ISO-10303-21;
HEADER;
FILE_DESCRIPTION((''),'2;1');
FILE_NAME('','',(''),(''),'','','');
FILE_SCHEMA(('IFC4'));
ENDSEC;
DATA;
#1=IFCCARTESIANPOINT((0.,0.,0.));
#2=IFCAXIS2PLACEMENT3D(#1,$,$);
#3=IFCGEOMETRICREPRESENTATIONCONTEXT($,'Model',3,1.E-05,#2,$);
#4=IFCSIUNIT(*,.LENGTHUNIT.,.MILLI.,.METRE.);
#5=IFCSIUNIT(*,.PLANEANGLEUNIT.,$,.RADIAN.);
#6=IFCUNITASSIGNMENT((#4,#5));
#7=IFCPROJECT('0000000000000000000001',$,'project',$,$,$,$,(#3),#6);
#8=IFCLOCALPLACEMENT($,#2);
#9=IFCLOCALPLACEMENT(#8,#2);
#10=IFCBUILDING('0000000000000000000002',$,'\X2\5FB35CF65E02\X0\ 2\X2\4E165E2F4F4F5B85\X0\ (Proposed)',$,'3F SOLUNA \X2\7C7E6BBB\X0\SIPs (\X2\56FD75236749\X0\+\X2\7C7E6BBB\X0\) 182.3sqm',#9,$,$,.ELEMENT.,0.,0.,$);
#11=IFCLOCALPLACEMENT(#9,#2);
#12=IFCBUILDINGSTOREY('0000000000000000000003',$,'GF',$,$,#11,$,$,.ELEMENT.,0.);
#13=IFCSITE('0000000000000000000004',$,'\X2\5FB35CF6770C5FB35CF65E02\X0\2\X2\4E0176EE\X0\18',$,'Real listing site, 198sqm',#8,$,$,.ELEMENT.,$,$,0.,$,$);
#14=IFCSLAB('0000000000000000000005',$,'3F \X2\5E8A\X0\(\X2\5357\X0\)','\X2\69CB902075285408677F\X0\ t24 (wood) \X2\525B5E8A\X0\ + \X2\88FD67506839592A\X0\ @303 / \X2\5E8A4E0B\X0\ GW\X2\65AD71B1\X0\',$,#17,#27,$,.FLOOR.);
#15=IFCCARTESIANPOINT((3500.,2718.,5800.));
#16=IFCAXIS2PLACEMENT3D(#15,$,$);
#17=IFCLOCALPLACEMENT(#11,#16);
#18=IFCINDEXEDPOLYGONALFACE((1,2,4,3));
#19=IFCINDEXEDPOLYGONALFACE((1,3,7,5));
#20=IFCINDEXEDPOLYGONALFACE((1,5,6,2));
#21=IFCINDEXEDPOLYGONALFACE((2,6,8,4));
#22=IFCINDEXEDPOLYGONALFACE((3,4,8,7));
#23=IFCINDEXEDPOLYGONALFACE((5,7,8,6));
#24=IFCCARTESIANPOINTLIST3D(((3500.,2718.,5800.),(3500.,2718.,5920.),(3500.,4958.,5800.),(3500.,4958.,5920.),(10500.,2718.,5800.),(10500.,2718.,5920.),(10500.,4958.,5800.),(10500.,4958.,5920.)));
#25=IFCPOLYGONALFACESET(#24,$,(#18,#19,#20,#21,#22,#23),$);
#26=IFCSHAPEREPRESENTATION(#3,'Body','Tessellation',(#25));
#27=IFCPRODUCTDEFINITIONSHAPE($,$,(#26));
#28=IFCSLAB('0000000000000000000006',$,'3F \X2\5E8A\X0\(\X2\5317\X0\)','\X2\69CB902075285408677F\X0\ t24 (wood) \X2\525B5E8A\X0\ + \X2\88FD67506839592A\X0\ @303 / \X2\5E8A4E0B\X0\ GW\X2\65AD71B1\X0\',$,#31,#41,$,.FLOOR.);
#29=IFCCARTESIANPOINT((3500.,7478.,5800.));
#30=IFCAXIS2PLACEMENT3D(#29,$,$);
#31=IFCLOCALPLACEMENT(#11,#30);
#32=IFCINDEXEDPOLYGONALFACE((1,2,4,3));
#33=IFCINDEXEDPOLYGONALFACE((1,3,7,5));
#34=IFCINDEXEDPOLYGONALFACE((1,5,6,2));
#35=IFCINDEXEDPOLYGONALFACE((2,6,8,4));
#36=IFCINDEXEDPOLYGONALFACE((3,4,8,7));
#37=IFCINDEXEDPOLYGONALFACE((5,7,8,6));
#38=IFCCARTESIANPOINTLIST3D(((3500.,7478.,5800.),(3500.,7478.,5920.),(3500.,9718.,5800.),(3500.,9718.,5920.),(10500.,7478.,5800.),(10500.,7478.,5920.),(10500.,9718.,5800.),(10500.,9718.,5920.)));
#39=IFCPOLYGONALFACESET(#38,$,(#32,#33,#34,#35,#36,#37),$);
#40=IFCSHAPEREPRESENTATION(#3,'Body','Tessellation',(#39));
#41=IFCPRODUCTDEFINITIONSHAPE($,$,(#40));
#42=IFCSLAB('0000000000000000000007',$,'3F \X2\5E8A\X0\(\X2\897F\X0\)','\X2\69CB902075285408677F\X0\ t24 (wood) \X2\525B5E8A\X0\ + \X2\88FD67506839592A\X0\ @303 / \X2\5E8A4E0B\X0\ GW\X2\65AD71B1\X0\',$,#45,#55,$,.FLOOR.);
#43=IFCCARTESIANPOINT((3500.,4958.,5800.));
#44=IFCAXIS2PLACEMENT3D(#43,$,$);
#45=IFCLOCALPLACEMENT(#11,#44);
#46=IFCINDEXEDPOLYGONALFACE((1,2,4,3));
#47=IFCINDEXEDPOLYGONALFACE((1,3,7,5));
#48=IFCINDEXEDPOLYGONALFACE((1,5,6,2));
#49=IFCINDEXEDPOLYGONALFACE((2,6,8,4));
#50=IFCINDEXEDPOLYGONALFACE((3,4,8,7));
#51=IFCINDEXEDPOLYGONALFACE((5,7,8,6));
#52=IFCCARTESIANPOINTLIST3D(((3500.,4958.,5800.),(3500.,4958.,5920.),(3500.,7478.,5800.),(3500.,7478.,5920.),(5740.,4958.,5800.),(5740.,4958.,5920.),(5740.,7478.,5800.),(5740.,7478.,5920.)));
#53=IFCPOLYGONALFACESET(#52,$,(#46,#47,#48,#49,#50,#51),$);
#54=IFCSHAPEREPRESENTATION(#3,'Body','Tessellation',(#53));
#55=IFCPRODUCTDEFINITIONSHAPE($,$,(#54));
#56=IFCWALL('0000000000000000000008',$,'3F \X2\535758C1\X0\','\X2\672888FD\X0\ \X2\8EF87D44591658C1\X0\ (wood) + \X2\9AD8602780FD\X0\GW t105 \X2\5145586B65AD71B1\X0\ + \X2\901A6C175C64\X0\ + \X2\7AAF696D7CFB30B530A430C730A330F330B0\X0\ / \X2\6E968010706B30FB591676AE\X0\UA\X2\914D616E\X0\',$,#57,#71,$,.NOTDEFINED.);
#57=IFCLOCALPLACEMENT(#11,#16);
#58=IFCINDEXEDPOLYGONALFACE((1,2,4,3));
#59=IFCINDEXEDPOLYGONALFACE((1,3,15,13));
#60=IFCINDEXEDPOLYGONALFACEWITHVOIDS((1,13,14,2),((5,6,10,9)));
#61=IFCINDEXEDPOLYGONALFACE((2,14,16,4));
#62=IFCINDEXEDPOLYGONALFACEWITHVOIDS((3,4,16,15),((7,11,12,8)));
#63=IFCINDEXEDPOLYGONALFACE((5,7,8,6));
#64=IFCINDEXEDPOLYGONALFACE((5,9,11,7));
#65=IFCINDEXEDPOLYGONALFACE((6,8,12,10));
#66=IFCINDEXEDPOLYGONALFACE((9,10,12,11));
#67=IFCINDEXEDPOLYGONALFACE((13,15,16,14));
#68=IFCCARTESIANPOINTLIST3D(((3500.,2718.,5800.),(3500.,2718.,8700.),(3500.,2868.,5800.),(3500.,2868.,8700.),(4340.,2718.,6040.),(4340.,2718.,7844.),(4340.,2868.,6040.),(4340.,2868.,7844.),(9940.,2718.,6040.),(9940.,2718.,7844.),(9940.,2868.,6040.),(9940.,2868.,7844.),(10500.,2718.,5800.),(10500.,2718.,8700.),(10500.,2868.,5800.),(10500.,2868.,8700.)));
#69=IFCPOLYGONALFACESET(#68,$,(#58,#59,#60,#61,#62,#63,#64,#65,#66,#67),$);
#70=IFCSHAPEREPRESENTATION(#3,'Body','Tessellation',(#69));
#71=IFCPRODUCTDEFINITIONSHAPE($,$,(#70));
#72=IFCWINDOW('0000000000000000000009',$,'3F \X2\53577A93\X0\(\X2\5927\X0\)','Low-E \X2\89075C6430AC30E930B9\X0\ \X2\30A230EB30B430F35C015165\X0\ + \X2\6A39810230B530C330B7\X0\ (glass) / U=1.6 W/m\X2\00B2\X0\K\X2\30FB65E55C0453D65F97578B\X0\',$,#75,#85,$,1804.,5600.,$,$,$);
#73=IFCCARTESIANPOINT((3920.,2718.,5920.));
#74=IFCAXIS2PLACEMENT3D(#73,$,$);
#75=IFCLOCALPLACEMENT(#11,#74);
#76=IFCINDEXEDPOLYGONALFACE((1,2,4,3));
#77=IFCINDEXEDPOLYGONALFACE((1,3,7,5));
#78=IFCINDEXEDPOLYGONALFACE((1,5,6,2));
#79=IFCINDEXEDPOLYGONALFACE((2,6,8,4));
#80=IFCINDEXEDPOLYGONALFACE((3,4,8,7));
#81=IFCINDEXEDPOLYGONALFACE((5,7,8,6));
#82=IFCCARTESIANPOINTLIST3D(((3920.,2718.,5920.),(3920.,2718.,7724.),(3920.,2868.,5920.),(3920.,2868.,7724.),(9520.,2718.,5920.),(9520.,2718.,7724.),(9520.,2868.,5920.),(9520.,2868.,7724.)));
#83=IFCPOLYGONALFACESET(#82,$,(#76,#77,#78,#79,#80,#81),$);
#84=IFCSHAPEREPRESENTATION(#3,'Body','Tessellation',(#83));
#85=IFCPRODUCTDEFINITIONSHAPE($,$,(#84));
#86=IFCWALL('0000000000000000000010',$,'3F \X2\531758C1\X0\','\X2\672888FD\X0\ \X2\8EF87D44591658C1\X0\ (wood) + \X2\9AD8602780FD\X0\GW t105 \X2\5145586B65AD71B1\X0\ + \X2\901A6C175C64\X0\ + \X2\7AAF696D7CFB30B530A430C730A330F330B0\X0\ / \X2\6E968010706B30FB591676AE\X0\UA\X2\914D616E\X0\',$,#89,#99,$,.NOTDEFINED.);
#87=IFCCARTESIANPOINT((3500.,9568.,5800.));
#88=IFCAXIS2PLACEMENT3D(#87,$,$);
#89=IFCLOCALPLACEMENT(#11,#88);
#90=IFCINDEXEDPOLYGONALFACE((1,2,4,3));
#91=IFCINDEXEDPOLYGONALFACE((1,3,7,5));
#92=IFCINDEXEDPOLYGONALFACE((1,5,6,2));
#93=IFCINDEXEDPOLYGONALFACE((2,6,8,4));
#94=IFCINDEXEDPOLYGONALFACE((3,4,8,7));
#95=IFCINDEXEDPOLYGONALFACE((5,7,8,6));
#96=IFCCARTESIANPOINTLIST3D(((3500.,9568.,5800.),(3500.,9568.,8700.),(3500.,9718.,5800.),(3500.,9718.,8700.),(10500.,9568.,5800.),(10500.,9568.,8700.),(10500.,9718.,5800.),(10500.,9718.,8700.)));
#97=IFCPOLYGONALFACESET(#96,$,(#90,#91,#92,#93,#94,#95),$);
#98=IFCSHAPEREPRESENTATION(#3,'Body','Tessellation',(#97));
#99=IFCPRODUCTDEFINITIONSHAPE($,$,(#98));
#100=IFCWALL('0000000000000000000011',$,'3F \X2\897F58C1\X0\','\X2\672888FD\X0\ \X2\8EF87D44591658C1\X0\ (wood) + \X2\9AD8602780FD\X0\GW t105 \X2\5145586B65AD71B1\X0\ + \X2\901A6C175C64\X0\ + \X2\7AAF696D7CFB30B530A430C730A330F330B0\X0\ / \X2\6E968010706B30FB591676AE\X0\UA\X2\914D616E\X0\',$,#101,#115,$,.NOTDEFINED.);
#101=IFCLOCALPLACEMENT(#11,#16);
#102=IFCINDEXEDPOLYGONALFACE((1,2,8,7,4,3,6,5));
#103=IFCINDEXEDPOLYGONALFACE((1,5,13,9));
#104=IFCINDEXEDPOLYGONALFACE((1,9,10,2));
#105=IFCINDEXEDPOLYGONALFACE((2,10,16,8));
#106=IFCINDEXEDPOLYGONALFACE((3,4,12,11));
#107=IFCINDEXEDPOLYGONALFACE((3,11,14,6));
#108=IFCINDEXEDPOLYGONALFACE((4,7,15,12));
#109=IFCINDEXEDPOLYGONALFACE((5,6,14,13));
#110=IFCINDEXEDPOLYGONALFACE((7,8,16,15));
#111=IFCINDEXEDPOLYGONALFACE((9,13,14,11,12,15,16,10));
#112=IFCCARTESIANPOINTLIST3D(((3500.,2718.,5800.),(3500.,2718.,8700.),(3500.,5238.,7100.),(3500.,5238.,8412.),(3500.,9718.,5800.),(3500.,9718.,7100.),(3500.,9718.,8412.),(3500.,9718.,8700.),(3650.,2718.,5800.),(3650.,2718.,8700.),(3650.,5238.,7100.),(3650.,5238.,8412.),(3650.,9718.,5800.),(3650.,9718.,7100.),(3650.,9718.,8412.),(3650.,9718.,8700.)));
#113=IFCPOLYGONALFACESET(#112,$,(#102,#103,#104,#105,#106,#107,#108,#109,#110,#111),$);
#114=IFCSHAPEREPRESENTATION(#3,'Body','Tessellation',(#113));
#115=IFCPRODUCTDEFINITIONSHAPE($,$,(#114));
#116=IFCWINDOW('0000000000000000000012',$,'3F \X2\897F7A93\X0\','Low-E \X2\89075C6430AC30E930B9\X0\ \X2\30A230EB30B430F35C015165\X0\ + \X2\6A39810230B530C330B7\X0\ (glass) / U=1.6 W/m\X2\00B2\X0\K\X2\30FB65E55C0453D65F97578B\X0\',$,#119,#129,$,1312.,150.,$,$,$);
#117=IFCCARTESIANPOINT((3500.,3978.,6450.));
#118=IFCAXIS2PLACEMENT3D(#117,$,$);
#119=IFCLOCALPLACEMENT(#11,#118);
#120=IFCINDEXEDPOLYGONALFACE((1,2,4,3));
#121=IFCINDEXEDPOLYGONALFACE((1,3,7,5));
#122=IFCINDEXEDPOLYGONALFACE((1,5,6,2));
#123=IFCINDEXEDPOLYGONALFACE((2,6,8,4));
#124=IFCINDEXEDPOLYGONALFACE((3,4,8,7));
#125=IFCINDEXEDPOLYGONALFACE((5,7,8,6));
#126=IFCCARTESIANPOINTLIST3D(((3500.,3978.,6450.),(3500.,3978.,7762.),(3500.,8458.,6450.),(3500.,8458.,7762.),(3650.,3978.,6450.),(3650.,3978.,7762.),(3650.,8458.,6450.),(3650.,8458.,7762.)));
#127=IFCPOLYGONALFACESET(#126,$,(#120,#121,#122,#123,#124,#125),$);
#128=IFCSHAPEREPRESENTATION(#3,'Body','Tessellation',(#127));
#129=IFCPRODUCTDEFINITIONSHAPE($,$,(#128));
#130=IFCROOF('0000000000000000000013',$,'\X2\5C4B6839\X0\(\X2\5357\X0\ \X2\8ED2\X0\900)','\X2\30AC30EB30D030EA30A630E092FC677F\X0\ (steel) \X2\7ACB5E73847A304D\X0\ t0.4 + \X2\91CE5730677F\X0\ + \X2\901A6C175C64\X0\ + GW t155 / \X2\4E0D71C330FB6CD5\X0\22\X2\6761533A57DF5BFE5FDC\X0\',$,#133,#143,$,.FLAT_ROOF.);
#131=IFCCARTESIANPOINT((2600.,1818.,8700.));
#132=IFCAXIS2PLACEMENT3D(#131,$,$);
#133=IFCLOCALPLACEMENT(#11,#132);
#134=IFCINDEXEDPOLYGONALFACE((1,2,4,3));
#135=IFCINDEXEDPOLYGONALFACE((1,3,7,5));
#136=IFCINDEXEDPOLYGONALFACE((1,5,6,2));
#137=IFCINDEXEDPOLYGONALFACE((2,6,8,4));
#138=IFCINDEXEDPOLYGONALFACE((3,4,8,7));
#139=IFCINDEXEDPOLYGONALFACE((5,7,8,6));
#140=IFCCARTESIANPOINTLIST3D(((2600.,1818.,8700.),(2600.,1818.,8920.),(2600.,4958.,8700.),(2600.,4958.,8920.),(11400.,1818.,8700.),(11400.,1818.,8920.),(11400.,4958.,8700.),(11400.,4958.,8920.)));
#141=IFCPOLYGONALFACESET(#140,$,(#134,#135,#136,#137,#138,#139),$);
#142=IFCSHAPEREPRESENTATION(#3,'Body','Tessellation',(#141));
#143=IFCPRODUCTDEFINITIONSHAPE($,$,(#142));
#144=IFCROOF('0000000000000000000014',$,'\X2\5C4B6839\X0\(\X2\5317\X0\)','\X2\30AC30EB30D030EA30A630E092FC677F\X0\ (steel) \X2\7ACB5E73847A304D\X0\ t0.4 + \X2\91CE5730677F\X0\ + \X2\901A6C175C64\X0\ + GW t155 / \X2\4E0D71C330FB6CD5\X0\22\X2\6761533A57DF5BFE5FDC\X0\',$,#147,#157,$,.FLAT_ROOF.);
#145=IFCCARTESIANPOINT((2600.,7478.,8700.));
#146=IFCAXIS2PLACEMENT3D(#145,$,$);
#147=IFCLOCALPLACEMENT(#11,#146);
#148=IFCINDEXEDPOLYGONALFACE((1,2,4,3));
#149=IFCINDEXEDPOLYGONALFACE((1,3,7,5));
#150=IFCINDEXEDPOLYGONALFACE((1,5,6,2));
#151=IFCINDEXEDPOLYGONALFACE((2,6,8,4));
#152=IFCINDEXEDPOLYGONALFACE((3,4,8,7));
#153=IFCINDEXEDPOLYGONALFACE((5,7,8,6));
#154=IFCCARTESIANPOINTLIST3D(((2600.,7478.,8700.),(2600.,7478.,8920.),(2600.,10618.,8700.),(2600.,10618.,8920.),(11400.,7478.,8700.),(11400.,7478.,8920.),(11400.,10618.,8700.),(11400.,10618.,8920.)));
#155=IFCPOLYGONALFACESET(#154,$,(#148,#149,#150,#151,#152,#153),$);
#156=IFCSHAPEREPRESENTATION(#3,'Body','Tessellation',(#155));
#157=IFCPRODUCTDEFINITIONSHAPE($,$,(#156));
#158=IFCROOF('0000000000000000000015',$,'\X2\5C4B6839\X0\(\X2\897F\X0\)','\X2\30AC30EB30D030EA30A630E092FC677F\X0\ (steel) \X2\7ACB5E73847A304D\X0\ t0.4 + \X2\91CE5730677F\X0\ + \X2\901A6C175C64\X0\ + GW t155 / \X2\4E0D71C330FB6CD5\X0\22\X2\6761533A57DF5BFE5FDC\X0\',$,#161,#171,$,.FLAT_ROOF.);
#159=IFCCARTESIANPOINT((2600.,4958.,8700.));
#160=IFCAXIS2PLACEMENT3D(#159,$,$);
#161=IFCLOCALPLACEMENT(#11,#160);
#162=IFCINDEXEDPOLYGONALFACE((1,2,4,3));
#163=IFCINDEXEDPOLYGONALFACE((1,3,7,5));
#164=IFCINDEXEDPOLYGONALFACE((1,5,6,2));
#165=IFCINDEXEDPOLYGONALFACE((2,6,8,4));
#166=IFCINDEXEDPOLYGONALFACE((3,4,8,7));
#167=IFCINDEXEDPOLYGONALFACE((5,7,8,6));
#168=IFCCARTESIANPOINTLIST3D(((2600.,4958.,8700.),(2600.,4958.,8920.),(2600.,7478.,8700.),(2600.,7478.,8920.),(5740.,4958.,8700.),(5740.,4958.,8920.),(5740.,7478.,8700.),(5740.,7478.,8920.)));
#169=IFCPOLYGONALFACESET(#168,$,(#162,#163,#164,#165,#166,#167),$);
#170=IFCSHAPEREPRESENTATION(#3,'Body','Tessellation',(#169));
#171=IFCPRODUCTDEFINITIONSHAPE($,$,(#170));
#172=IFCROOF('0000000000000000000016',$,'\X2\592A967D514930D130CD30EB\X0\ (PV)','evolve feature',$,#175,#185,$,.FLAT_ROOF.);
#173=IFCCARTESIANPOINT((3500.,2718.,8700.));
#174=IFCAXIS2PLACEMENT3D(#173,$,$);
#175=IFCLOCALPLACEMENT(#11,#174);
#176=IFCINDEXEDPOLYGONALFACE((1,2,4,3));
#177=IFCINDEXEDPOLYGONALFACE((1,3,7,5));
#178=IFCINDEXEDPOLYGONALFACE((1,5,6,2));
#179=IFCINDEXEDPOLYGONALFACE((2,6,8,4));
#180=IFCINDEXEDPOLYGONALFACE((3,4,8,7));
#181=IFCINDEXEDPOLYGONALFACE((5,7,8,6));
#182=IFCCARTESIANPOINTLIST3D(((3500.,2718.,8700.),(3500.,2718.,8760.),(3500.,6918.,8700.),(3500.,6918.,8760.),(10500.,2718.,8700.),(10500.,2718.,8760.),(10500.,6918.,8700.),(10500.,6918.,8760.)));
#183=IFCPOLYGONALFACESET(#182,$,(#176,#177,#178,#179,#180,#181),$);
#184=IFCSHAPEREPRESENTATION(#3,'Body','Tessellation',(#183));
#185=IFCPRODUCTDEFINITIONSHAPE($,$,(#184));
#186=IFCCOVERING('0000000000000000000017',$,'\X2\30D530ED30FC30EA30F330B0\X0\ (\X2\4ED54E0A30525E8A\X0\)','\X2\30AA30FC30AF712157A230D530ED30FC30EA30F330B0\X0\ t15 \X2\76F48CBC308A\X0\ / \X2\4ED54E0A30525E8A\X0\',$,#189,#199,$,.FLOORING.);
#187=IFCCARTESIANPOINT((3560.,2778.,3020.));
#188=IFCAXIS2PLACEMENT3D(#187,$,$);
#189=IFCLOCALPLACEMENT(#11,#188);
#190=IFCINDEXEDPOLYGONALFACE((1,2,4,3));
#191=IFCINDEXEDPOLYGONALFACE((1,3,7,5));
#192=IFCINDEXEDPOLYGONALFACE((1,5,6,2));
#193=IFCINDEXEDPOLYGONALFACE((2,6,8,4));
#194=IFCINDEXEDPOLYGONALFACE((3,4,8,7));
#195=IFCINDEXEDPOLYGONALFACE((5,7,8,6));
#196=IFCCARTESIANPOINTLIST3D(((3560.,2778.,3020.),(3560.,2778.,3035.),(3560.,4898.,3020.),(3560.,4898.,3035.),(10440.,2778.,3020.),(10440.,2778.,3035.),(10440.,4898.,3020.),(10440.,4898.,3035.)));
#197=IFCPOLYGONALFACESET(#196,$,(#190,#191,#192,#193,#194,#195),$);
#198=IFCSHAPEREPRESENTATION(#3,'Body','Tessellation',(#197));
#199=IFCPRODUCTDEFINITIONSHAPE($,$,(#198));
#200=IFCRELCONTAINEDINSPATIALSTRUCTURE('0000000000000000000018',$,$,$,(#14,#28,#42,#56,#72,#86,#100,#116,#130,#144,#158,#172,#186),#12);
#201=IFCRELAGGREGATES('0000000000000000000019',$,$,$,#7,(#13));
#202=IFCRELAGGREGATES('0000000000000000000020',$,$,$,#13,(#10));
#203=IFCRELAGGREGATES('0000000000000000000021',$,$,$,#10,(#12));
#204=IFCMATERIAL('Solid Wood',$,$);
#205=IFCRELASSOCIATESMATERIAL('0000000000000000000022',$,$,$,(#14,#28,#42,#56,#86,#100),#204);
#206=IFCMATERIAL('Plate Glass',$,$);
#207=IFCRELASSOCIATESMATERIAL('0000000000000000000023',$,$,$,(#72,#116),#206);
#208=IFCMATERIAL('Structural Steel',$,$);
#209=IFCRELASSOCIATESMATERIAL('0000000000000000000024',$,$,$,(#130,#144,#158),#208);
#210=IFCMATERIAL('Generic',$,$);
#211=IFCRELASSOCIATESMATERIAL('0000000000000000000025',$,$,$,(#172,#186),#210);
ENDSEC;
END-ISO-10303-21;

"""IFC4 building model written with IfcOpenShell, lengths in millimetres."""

from ifc_helpers import new_model, si_unit, frame, frame_2d, origin, place, context, project, spatial, rectangle, extrude, material, element, fill, save


model = new_model("IFC4")

# Units and contexts
model_context = context("Model", 3, precision=1e-05, world=origin())
ifc_project = project(units=[si_unit("LENGTHUNIT", "METRE", prefix="MILLI"), si_unit("PLANEANGLEUNIT", "RADIAN")], contexts=[model_context])

# Site, building, storey
site_placement = place(None, origin())
site = spatial("IfcSite", under=ifc_project, at=site_placement, Name="徳島県徳島市2丁目18", ObjectType="Real listing site, 198sqm", CompositionType="ELEMENT", RefElevation=0.0)
building_placement = place(site_placement, origin())
building = spatial("IfcBuilding", under=site, at=building_placement, Name="徳島市 2世帯住宅 (Proposed)", ObjectType="3F SOLUNA 籾殻SIPs (国産杉+籾殻) 182.3sqm", CompositionType="ELEMENT", ElevationOfRefHeight=0.0, ElevationOfTerrain=0.0)
storey_placement = place(building_placement, origin())
storey = spatial("IfcBuildingStorey", under=building, at=storey_placement, Name="GF", CompositionType="ELEMENT", Elevation=0.0)

# Slabs
ifc_material_1 = material(Name="Solid Wood")
slab_1_placement = place(storey_placement, frame((3500.0, 2718.0, 5800.0)))
element("IfcSlab", 1, at=slab_1_placement, inside=storey, material=ifc_material_1, Name="3F 床(南)", Description="構造用合板 t24 (wood) 剛床 + 製材根太 @303 / 床下 GW断熱", PredefinedType="FLOOR", context=model_context, shape_type="SweptSolid", body=[
    extrude(rectangle(XDim=7000.0, YDim=2240.0, at=frame_2d((3500.0, 1120.0))), frame((3500.0, 2718.0, 5800.0)), (0.0, 0.0, 1.0), 120.0),
])
slab_2_placement = place(storey_placement, frame((3500.0, 7478.0, 5800.0)))
element("IfcSlab", 2, at=slab_2_placement, inside=storey, material=ifc_material_1, Name="3F 床(北)", Description="構造用合板 t24 (wood) 剛床 + 製材根太 @303 / 床下 GW断熱", PredefinedType="FLOOR", context=model_context, shape_type="SweptSolid", body=[
    extrude(rectangle(XDim=7000.0, YDim=2240.0, at=frame_2d((3500.0, 1120.0))), frame((3500.0, 7478.0, 5800.0)), (0.0, 0.0, 1.0), 120.0),
])
slab_3_placement = place(storey_placement, frame((3500.0, 4958.0, 5800.0)))
element("IfcSlab", 3, at=slab_3_placement, inside=storey, material=ifc_material_1, Name="3F 床(西)", Description="構造用合板 t24 (wood) 剛床 + 製材根太 @303 / 床下 GW断熱", PredefinedType="FLOOR", context=model_context, shape_type="SweptSolid", body=[
    extrude(rectangle(XDim=2240.0, YDim=2520.0, at=frame_2d((1120.0, 1260.0))), frame((3500.0, 4958.0, 5800.0)), (0.0, 0.0, 1.0), 120.0),
])

# Wall, opening, window
wall_1_placement = place(storey_placement, frame((3500.0, 2718.0, 5800.0)))
wall_1 = element("IfcWall", 4, at=wall_1_placement, inside=storey, material=ifc_material_1, Name="3F 南壁", Description="木製 軸組外壁 (wood) + 高性能GW t105 充填断熱 + 通気層 + 窯業系サイディング / 準耐火・外皮UA配慮", PredefinedType="NOTDEFINED", context=model_context, shape_type="SweptSolid", body=[
    extrude(rectangle(XDim=7000.0, YDim=150.0, at=frame_2d((3500.0, 75.0))), frame((3500.0, 2718.0, 5800.0)), (0.0, 0.0, 1.0), 2900.0),
])
opening_1_placement = place(storey_placement, frame((3920.0, 2718.0, 5920.0)))
opening_1 = element("IfcOpeningElement", 5, at=opening_1_placement, cuts=wall_1, PredefinedType="NOTDEFINED", context=model_context, shape_type="SweptSolid", body=[
    extrude(rectangle(XDim=5600.0, YDim=150.0, at=frame_2d((2800.0, 75.0))), frame((3920.0, 2718.0, 5920.0)), (0.0, 0.0, 1.0), 1804.0),
])
ifc_material_2 = material(Name="Plate Glass")
window_1_placement = place(storey_placement, frame((3920.0, 2718.0, 5920.0)))
window_1 = element("IfcWindow", 6, at=window_1_placement, inside=storey, material=ifc_material_2, Name="3F 南窓(大)", Description="Low-E 複層ガラス アルゴン封入 + 樹脂サッシ (glass) / U=1.6 W/m²K・日射取得型", OverallHeight=1804.0, OverallWidth=5600.0, context=model_context, shape_type="SweptSolid", body=[
    extrude(rectangle(XDim=5600.0, YDim=150.0, at=frame_2d((2800.0, 75.0))), frame((3920.0, 2718.0, 5920.0)), (0.0, 0.0, 1.0), 1804.0),
])
fill(opening_1, window_1)

# Wall
wall_2_placement = place(storey_placement, frame((3500.0, 9568.0, 5800.0)))
element("IfcWall", 7, at=wall_2_placement, inside=storey, material=ifc_material_1, Name="3F 北壁", Description="木製 軸組外壁 (wood) + 高性能GW t105 充填断熱 + 通気層 + 窯業系サイディング / 準耐火・外皮UA配慮", PredefinedType="NOTDEFINED", context=model_context, shape_type="SweptSolid", body=[
    extrude(rectangle(XDim=7000.0, YDim=150.0, at=frame_2d((3500.0, 75.0))), frame((3500.0, 9568.0, 5800.0)), (0.0, 0.0, 1.0), 2900.0),
])

# Wall, opening, window
wall_3_placement = place(storey_placement, frame((3500.0, 2718.0, 5800.0)))
wall_3 = element("IfcWall", 8, at=wall_3_placement, inside=storey, material=ifc_material_1, Name="3F 西壁", Description="木製 軸組外壁 (wood) + 高性能GW t105 充填断熱 + 通気層 + 窯業系サイディング / 準耐火・外皮UA配慮", PredefinedType="NOTDEFINED", context=model_context, shape_type="SweptSolid", body=[
    extrude(rectangle(XDim=150.0, YDim=7000.0, at=frame_2d((75.0, 3500.0))), frame((3500.0, 2718.0, 5800.0)), (0.0, 0.0, 1.0), 2900.0),
])
opening_2_placement = place(storey_placement, frame((3500.0, 3978.0, 6450.0)))
opening_2 = element("IfcOpeningElement", 9, at=opening_2_placement, cuts=wall_3, PredefinedType="NOTDEFINED", context=model_context, shape_type="SweptSolid", body=[
    extrude(rectangle(XDim=150.0, YDim=4480.0, at=frame_2d((75.0, 2240.0))), frame((3500.0, 3978.0, 6450.0)), (0.0, 0.0, 1.0), 1312.0),
])
window_2_placement = place(storey_placement, frame((3500.0, 3978.0, 6450.0)))
window_2 = element("IfcWindow", 10, at=window_2_placement, inside=storey, material=ifc_material_2, Name="3F 西窓", Description="Low-E 複層ガラス アルゴン封入 + 樹脂サッシ (glass) / U=1.6 W/m²K・日射取得型", OverallHeight=1312.0, OverallWidth=150.0, context=model_context, shape_type="SweptSolid", body=[
    extrude(rectangle(XDim=150.0, YDim=4480.0, at=frame_2d((75.0, 2240.0))), frame((3500.0, 3978.0, 6450.0)), (0.0, 0.0, 1.0), 1312.0),
])
fill(opening_2, window_2)

# Roofs
ifc_material_3 = material(Name="Structural Steel")
roof_1_placement = place(storey_placement, frame((2600.0, 1818.0, 8700.0)))
element("IfcRoof", 11, at=roof_1_placement, inside=storey, material=ifc_material_3, Name="屋根(南 軒900)", Description="ガルバリウム鋼板 (steel) 立平葺き t0.4 + 野地板 + 通気層 + GW t155 / 不燃・法22条区域対応", PredefinedType="FLAT_ROOF", context=model_context, shape_type="SweptSolid", body=[
    extrude(rectangle(XDim=8800.0, YDim=3140.0, at=frame_2d((4400.0, 1570.0))), frame((2600.0, 1818.0, 8700.0)), (0.0, 0.0, 1.0), 220.0),
])
roof_2_placement = place(storey_placement, frame((2600.0, 7478.0, 8700.0)))
element("IfcRoof", 12, at=roof_2_placement, inside=storey, material=ifc_material_3, Name="屋根(北)", Description="ガルバリウム鋼板 (steel) 立平葺き t0.4 + 野地板 + 通気層 + GW t155 / 不燃・法22条区域対応", PredefinedType="FLAT_ROOF", context=model_context, shape_type="SweptSolid", body=[
    extrude(rectangle(XDim=8800.0, YDim=3140.0, at=frame_2d((4400.0, 1570.0))), frame((2600.0, 7478.0, 8700.0)), (0.0, 0.0, 1.0), 220.0),
])
roof_3_placement = place(storey_placement, frame((2600.0, 4958.0, 8700.0)))
element("IfcRoof", 13, at=roof_3_placement, inside=storey, material=ifc_material_3, Name="屋根(西)", Description="ガルバリウム鋼板 (steel) 立平葺き t0.4 + 野地板 + 通気層 + GW t155 / 不燃・法22条区域対応", PredefinedType="FLAT_ROOF", context=model_context, shape_type="SweptSolid", body=[
    extrude(rectangle(XDim=3140.0, YDim=2520.0, at=frame_2d((1570.0, 1260.0))), frame((2600.0, 4958.0, 8700.0)), (0.0, 0.0, 1.0), 220.0),
])
ifc_material_4 = material(Name="Generic")
roof_4_placement = place(storey_placement, frame((3500.0, 2718.0, 8700.0)))
element("IfcRoof", 14, at=roof_4_placement, inside=storey, material=ifc_material_4, Name="太陽光パネル (PV)", Description="evolve feature", PredefinedType="FLAT_ROOF", context=model_context, shape_type="SweptSolid", body=[
    extrude(rectangle(XDim=7000.0, YDim=4200.0, at=frame_2d((3500.0, 2100.0))), frame((3500.0, 2718.0, 8700.0)), (0.0, 0.0, 1.0), 60.0),
])

# Covering
covering_1_placement = place(storey_placement, frame((3560.0, 2778.0, 3020.0)))
element("IfcCovering", 15, at=covering_1_placement, inside=storey, material=ifc_material_4, Name="フローリング (仕上げ床)", Description="オーク無垢フローリング t15 直貼り / 仕上げ床", PredefinedType="FLOORING", context=model_context, shape_type="SweptSolid", body=[
    extrude(rectangle(XDim=6880.0, YDim=2120.0, at=frame_2d((3440.0, 1060.0))), frame((3560.0, 2778.0, 3020.0)), (0.0, 0.0, 1.0), 15.0),
])

save(model, "model.ifc")
